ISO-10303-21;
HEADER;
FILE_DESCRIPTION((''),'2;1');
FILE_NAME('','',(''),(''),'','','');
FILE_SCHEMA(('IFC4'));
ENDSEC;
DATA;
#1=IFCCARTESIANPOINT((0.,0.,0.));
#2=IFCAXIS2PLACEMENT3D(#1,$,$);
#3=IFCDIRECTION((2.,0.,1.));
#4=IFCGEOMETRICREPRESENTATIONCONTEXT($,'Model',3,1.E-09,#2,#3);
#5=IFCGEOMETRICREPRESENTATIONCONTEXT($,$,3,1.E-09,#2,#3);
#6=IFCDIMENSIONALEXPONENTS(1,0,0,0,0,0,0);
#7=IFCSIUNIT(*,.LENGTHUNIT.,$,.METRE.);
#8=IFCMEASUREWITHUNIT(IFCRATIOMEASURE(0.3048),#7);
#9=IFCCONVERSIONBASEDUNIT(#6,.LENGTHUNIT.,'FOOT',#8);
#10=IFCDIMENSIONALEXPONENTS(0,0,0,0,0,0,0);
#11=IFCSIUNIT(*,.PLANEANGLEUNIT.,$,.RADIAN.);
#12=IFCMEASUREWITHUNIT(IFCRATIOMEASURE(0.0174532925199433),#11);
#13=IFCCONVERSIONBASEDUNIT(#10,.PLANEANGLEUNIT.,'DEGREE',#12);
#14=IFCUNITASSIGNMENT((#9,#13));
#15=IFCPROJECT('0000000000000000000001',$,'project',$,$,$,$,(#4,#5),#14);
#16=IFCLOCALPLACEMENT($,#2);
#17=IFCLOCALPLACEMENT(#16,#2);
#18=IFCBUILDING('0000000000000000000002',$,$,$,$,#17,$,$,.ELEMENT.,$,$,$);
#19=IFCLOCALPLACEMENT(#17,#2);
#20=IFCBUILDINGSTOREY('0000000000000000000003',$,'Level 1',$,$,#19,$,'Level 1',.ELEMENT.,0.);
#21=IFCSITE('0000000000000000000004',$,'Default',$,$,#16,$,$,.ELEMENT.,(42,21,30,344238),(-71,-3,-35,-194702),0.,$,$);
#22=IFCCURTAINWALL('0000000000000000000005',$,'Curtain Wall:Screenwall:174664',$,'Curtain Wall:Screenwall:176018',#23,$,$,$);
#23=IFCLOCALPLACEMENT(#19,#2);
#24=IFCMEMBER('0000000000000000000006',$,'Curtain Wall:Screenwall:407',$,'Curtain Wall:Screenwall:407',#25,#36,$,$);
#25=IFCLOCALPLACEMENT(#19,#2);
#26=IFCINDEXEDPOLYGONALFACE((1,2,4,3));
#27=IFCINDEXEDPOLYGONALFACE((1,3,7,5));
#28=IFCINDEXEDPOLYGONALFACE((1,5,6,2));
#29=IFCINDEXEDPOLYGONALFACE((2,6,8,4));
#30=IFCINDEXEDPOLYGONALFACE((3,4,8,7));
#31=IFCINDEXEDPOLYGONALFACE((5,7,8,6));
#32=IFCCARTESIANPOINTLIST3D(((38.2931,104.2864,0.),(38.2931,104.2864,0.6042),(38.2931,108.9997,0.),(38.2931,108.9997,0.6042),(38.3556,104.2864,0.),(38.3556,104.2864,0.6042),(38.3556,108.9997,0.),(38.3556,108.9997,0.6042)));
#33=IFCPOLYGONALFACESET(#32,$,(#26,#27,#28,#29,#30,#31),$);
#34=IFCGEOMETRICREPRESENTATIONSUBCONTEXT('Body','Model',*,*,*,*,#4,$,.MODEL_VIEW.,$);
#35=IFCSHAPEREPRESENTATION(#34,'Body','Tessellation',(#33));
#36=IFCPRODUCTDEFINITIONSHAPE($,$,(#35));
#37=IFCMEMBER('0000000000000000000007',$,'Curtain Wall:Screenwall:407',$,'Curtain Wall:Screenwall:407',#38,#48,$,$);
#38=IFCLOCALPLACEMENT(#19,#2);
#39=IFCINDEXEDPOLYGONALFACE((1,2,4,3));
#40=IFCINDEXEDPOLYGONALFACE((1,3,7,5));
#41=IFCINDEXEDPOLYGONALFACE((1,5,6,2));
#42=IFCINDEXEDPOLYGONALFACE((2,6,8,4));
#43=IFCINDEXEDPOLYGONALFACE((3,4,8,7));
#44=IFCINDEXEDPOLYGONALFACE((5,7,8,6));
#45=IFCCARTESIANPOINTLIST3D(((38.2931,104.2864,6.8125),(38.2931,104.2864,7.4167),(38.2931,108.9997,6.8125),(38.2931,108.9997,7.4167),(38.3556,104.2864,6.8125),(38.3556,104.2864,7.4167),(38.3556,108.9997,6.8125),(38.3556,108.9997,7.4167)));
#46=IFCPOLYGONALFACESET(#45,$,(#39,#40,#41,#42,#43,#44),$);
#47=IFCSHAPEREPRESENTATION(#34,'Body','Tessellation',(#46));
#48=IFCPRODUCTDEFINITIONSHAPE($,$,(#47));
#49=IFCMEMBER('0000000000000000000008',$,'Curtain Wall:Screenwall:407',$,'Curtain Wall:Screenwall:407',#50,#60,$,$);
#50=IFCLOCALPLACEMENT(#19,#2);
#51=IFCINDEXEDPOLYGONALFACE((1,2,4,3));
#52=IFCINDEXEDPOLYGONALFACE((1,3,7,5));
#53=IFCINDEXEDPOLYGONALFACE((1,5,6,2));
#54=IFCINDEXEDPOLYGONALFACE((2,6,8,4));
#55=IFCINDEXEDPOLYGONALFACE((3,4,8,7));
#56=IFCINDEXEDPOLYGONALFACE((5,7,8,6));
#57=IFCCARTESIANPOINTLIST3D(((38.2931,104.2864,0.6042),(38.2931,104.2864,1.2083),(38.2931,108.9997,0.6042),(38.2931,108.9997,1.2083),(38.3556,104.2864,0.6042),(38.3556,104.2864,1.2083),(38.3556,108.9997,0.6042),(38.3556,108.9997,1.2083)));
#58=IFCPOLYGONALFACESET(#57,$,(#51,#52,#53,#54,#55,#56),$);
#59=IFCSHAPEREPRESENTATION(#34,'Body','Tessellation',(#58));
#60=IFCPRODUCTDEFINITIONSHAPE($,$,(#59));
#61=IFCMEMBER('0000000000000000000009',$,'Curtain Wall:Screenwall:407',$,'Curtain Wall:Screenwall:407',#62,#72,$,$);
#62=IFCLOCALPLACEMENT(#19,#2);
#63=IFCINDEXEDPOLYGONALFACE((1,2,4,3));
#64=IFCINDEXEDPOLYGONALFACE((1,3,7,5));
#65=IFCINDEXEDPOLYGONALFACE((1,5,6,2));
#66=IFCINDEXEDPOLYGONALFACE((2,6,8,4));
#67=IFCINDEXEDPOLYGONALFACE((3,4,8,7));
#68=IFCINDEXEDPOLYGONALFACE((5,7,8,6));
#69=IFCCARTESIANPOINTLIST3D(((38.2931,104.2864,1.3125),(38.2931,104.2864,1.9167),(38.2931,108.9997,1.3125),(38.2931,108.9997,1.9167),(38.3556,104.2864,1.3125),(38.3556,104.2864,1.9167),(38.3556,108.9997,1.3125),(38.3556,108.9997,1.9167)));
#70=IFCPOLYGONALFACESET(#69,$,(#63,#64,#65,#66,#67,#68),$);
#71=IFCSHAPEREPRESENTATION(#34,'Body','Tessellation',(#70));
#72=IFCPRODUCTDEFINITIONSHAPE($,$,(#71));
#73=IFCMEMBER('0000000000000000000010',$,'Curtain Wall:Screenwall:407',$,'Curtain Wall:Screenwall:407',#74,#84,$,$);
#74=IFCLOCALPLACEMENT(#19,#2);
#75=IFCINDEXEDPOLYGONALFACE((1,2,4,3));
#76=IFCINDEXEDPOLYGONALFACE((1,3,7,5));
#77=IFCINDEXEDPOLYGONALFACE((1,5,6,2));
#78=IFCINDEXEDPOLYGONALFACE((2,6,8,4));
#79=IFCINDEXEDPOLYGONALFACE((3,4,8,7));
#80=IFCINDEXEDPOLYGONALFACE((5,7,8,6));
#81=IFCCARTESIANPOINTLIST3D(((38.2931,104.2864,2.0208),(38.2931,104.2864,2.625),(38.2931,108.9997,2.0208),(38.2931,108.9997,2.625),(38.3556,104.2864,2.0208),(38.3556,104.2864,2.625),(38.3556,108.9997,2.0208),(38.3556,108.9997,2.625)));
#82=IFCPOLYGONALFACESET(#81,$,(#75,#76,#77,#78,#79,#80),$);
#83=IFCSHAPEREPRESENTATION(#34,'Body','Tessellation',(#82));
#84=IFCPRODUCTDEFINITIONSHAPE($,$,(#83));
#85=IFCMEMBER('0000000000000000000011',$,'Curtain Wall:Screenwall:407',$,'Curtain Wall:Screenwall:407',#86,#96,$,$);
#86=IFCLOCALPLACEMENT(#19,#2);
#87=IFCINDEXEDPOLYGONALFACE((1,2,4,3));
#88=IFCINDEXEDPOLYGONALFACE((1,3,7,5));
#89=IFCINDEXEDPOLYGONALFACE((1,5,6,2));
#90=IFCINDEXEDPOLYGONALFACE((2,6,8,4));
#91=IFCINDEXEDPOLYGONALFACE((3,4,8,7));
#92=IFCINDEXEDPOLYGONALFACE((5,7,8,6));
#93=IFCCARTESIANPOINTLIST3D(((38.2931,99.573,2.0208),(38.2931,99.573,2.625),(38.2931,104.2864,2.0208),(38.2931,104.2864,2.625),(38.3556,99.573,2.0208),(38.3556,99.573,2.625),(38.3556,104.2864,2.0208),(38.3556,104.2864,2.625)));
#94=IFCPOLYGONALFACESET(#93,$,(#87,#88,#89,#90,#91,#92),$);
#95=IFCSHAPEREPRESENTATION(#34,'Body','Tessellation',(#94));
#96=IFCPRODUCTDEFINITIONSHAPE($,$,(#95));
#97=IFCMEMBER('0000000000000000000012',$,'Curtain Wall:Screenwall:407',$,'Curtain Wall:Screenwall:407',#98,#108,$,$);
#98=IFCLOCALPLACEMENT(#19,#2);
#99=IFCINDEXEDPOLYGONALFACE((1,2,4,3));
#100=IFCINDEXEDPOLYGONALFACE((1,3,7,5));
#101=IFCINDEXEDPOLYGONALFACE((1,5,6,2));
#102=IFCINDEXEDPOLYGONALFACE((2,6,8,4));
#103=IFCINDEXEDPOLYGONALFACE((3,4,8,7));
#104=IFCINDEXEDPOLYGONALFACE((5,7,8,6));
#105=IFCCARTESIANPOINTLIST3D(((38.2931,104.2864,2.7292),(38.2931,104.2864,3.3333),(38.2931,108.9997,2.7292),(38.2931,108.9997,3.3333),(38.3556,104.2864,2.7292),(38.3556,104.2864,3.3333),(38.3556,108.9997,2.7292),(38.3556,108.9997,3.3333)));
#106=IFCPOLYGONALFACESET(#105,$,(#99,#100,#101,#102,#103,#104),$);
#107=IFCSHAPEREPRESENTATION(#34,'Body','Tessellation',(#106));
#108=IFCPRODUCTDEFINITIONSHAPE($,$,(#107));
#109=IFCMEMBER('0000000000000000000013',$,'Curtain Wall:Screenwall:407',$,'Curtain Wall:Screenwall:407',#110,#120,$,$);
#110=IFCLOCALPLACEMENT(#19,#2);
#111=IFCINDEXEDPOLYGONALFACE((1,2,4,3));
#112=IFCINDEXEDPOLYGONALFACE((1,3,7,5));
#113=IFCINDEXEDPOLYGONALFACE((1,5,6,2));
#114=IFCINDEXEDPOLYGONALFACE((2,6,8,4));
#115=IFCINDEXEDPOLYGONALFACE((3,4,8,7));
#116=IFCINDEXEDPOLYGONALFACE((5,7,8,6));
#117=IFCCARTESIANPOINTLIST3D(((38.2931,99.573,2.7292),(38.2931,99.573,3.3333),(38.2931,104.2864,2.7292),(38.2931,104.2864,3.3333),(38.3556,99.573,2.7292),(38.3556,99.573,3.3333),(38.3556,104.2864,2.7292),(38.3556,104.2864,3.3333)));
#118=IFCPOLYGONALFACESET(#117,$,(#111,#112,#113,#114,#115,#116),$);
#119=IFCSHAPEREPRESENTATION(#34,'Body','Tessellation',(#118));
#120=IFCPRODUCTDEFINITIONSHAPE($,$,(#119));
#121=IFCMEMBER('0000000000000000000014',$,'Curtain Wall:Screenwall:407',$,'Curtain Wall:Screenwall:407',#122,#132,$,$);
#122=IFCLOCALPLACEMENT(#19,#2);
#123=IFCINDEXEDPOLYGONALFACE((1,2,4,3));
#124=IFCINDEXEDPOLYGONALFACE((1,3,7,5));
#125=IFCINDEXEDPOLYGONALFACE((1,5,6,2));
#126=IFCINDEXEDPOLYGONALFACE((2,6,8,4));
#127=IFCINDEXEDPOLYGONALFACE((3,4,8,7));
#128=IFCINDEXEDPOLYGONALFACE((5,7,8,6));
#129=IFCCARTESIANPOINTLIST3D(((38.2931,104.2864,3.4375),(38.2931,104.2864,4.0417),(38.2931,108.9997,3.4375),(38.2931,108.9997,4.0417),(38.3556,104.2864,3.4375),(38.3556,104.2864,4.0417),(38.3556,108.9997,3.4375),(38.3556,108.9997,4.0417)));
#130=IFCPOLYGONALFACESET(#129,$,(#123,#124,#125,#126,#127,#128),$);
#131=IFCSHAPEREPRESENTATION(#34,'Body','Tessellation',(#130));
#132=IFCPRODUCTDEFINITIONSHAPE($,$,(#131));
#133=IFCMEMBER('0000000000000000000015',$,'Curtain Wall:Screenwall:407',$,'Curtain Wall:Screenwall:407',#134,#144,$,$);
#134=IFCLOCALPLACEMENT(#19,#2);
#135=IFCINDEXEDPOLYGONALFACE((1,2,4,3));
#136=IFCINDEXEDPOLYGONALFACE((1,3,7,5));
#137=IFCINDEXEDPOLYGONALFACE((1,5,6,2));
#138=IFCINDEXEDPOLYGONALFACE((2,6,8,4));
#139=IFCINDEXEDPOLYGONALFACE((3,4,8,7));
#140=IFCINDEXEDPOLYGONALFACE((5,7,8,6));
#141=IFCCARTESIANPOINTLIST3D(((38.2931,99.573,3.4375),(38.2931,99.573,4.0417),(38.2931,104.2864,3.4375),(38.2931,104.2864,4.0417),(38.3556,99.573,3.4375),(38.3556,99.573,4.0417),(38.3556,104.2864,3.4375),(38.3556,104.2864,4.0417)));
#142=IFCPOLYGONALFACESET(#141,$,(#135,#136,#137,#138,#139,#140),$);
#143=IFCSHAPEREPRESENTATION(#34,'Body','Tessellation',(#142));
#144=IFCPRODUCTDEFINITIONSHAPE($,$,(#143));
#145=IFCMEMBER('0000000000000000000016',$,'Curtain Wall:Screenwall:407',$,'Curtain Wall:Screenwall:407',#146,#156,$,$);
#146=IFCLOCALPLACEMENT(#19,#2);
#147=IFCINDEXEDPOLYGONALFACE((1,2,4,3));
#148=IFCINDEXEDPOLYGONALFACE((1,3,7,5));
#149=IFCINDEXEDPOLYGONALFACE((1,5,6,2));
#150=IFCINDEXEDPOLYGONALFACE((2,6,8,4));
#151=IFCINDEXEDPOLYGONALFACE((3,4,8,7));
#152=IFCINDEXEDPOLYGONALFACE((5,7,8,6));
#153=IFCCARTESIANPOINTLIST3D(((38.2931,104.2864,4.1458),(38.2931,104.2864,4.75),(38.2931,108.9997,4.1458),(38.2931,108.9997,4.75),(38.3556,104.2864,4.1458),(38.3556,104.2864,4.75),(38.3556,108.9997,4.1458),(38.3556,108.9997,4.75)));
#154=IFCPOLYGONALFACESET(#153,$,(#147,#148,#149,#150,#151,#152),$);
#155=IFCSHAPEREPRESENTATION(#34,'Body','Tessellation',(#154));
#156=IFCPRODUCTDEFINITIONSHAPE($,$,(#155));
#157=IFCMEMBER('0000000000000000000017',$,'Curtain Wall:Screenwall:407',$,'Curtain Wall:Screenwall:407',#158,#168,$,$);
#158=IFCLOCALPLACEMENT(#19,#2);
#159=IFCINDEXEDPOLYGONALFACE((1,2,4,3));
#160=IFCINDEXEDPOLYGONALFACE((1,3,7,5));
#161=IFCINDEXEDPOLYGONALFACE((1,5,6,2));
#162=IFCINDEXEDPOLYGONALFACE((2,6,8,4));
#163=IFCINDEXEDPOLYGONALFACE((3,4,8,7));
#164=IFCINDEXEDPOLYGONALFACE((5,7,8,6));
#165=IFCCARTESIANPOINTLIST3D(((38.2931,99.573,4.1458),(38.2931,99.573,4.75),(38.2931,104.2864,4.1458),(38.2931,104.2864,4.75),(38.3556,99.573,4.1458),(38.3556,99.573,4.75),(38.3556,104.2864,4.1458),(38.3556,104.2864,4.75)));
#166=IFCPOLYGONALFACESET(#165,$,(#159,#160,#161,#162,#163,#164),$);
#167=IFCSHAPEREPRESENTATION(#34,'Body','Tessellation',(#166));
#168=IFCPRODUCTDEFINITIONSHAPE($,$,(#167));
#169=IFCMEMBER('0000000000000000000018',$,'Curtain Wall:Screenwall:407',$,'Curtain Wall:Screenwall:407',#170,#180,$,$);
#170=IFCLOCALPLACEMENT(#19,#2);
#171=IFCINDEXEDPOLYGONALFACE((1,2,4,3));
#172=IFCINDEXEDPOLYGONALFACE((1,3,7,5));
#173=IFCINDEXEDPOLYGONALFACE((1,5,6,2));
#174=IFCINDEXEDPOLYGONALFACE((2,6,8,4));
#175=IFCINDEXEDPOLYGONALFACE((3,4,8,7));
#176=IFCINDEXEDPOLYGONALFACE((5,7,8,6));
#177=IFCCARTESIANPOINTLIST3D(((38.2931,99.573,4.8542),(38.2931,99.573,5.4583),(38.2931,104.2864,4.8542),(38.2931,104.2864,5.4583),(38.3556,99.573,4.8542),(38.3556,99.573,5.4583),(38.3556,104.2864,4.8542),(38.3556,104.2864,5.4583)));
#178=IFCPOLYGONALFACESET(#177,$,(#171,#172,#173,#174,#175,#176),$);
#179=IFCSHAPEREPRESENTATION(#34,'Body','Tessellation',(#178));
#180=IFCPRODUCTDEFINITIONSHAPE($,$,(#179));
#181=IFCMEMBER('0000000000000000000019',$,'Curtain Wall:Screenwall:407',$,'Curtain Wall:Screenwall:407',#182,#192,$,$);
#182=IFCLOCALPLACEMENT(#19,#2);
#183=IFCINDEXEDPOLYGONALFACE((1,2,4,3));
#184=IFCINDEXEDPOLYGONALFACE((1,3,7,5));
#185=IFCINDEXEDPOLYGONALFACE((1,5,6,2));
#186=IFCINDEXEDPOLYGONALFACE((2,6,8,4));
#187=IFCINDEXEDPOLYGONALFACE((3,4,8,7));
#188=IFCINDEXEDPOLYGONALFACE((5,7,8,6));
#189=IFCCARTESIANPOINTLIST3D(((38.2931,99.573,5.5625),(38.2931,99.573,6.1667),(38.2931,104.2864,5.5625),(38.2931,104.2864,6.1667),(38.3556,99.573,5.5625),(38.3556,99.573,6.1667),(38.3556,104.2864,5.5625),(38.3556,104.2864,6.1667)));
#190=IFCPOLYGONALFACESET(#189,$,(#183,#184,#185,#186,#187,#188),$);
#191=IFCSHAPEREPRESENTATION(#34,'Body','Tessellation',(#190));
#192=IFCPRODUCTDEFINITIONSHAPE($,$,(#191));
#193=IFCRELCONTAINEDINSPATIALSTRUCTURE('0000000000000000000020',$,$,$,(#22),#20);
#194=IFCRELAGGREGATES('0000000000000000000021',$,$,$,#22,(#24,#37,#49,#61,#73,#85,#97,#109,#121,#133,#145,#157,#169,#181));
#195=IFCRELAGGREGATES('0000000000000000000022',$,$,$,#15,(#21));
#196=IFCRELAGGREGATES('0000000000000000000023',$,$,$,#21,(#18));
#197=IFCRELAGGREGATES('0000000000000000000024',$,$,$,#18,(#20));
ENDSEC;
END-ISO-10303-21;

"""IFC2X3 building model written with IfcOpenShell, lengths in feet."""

from ifc_helpers import new_model, entity, si_unit, converted_unit, direction, frame, frame_2d, origin, origin_2d_with_axis, place, context, subcontext, project, spatial, rectangle, extrude, element, aggregate, save


model = new_model("IFC2X3")

# Units and contexts
model_context = context("Model", 3, precision=1e-09, world=origin(), true_north=direction((2.0, 0.0, 1.0)))
context_of_model = context(None, 3, precision=1e-09, world=origin(), true_north=direction((2.0, 0.0, 1.0)))
body_context = subcontext(model_context, "Body", "Model", "MODEL_VIEW")
ifc_project = project(units=[converted_unit("LENGTHUNIT", "FOOT", entity("IfcRatioMeasure", 0.3048), si_unit("LENGTHUNIT", "METRE"), dimensions=[1, 0, 0, 0, 0, 0, 0]), converted_unit("PLANEANGLEUNIT", "DEGREE", entity("IfcRatioMeasure", 0.0174532925199433), si_unit("PLANEANGLEUNIT", "RADIAN"), dimensions=[0, 0, 0, 0, 0, 0, 0])], contexts=[model_context, context_of_model])

# Site, building, storey
site_placement = place(None, origin())
site = spatial("IfcSite", under=ifc_project, at=site_placement, Name="Default", CompositionType="ELEMENT", RefLatitude=(42, 21, 30, 344238), RefLongitude=(-71, -3, -35, -194702), RefElevation=0.0)
building_placement = place(site_placement, origin())
building = spatial("IfcBuilding", under=site, at=building_placement, CompositionType="ELEMENT")
storey_placement = place(building_placement, origin())
storey = spatial("IfcBuildingStorey", under=building, at=storey_placement, Name="Level 1", LongName="Level 1", CompositionType="ELEMENT", Elevation=0.0)

# Curtain wall, members
curtain_wall_1_placement = place(storey_placement, origin())
curtain_wall_1 = element("IfcCurtainWall", 1, at=curtain_wall_1_placement, inside=storey, Name="Curtain Wall:Screenwall:174664", ObjectType="Curtain Wall:Screenwall:176018")
member_1_placement = place(curtain_wall_1_placement, frame((38.2931, 104.2864, 0.0)))
member_1 = element("IfcMember", 2, at=member_1_placement, Name="Curtain Wall:Screenwall:407", ObjectType="Curtain Wall:Screenwall:407", context=body_context, shape_type="SweptSolid", body=[
    extrude(rectangle(XDim=4.7134, YDim=0.0625, at=frame_2d((0.0, 0.0), x_axis=(1.0, 0.0))), frame((0.0312, 2.3567, 0.0), z_axis=(0.0, 0.0, 1.0), x_axis=(0.0, -1.0, 0.0)), (0.0, 0.0, 1.0), 0.6042),
])
member_2_placement = place(curtain_wall_1_placement, frame((38.2931, 104.2864, 6.8125)))
member_2 = element("IfcMember", 3, at=member_2_placement, Name="Curtain Wall:Screenwall:407", ObjectType="Curtain Wall:Screenwall:407", context=body_context, shape_type="SweptSolid", body=[
    extrude(rectangle(XDim=4.7134, YDim=0.0625, at=origin_2d_with_axis()), frame((0.0312, 2.3567, 0.0), z_axis=(0.0, 0.0, 1.0), x_axis=(0.0, 1.0, 0.0)), (0.0, 0.0, 1.0), 0.6042),
])
member_3_placement = place(curtain_wall_1_placement, frame((38.2931, 104.2864, 0.6042)))
member_3 = element("IfcMember", 4, at=member_3_placement, Name="Curtain Wall:Screenwall:407", ObjectType="Curtain Wall:Screenwall:407", context=body_context, shape_type="SweptSolid", body=[
    extrude(rectangle(XDim=4.7134, YDim=0.0625, at=origin_2d_with_axis()), frame((0.0312, 2.3567, 0.0), z_axis=(0.0, 0.0, 1.0), x_axis=(0.0, 1.0, 0.0)), (0.0, 0.0, 1.0), 0.6042),
])
member_4_placement = place(curtain_wall_1_placement, frame((38.2931, 104.2864, 1.3125)))
member_4 = element("IfcMember", 5, at=member_4_placement, Name="Curtain Wall:Screenwall:407", ObjectType="Curtain Wall:Screenwall:407", context=body_context, shape_type="SweptSolid", body=[
    extrude(rectangle(XDim=4.7134, YDim=0.0625, at=origin_2d_with_axis()), frame((0.0312, 2.3567, 0.0), z_axis=(0.0, 0.0, 1.0), x_axis=(0.0, 1.0, 0.0)), (0.0, 0.0, 1.0), 0.6042),
])
member_5_placement = place(curtain_wall_1_placement, frame((38.2931, 104.2864, 2.0208)))
member_5 = element("IfcMember", 6, at=member_5_placement, Name="Curtain Wall:Screenwall:407", ObjectType="Curtain Wall:Screenwall:407", context=body_context, shape_type="SweptSolid", body=[
    extrude(rectangle(XDim=4.7134, YDim=0.0625, at=origin_2d_with_axis()), frame((0.0312, 2.3567, 0.0), z_axis=(0.0, 0.0, 1.0), x_axis=(0.0, 1.0, 0.0)), (0.0, 0.0, 1.0), 0.6042),
])
member_6_placement = place(curtain_wall_1_placement, frame((38.2931, 99.573, 2.0208)))
member_6 = element("IfcMember", 7, at=member_6_placement, Name="Curtain Wall:Screenwall:407", ObjectType="Curtain Wall:Screenwall:407", context=body_context, shape_type="SweptSolid", body=[
    extrude(rectangle(XDim=4.7134, YDim=0.0625, at=frame_2d((0.0, 0.0), x_axis=(1.0, 0.0))), frame((0.0312, 2.3567, 0.0), z_axis=(0.0, 0.0, 1.0), x_axis=(0.0, 1.0, 0.0)), (0.0, 0.0, 1.0), 0.6042),
])
member_7_placement = place(curtain_wall_1_placement, frame((38.2931, 104.2864, 2.7292)))
member_7 = element("IfcMember", 8, at=member_7_placement, Name="Curtain Wall:Screenwall:407", ObjectType="Curtain Wall:Screenwall:407", context=body_context, shape_type="SweptSolid", body=[
    extrude(rectangle(XDim=4.7134, YDim=0.0625, at=origin_2d_with_axis()), frame((0.0312, 2.3567, 0.0), z_axis=(0.0, 0.0, 1.0), x_axis=(0.0, 1.0, 0.0)), (0.0, 0.0, 1.0), 0.6042),
])
member_8_placement = place(curtain_wall_1_placement, frame((38.2931, 99.573, 2.7292)))
member_8 = element("IfcMember", 9, at=member_8_placement, Name="Curtain Wall:Screenwall:407", ObjectType="Curtain Wall:Screenwall:407", context=body_context, shape_type="SweptSolid", body=[
    extrude(rectangle(XDim=4.7134, YDim=0.0625, at=frame_2d((0.0, 0.0), x_axis=(1.0, 0.0))), frame((0.0312, 2.3567, 0.0), z_axis=(0.0, 0.0, 1.0), x_axis=(0.0, 1.0, 0.0)), (0.0, 0.0, 1.0), 0.6042),
])
member_9_placement = place(curtain_wall_1_placement, frame((38.2931, 104.2864, 3.4375)))
member_9 = element("IfcMember", 10, at=member_9_placement, Name="Curtain Wall:Screenwall:407", ObjectType="Curtain Wall:Screenwall:407", context=body_context, shape_type="SweptSolid", body=[
    extrude(rectangle(XDim=4.7134, YDim=0.0625, at=origin_2d_with_axis()), frame((0.0312, 2.3567, 0.0), z_axis=(0.0, 0.0, 1.0), x_axis=(0.0, 1.0, 0.0)), (0.0, 0.0, 1.0), 0.6042),
])
member_10_placement = place(curtain_wall_1_placement, frame((38.2931, 99.573, 3.4375)))
member_10 = element("IfcMember", 11, at=member_10_placement, Name="Curtain Wall:Screenwall:407", ObjectType="Curtain Wall:Screenwall:407", context=body_context, shape_type="SweptSolid", body=[
    extrude(rectangle(XDim=4.7134, YDim=0.0625, at=frame_2d((0.0, 0.0), x_axis=(1.0, 0.0))), frame((0.0312, 2.3567, 0.0), z_axis=(0.0, 0.0, 1.0), x_axis=(0.0, 1.0, 0.0)), (0.0, 0.0, 1.0), 0.6042),
])
member_11_placement = place(curtain_wall_1_placement, frame((38.2931, 104.2864, 4.1458)))
member_11 = element("IfcMember", 12, at=member_11_placement, Name="Curtain Wall:Screenwall:407", ObjectType="Curtain Wall:Screenwall:407", context=body_context, shape_type="SweptSolid", body=[
    extrude(rectangle(XDim=4.7134, YDim=0.0625, at=origin_2d_with_axis()), frame((0.0312, 2.3567, 0.0), z_axis=(0.0, 0.0, 1.0), x_axis=(0.0, 1.0, 0.0)), (0.0, 0.0, 1.0), 0.6042),
])
member_12_placement = place(curtain_wall_1_placement, frame((38.2931, 99.573, 4.1458)))
member_12 = element("IfcMember", 13, at=member_12_placement, Name="Curtain Wall:Screenwall:407", ObjectType="Curtain Wall:Screenwall:407", context=body_context, shape_type="SweptSolid", body=[
    extrude(rectangle(XDim=4.7134, YDim=0.0625, at=frame_2d((0.0, 0.0), x_axis=(1.0, 0.0))), frame((0.0312, 2.3567, 0.0), z_axis=(0.0, 0.0, 1.0), x_axis=(0.0, 1.0, 0.0)), (0.0, 0.0, 1.0), 0.6042),
])
member_13_placement = place(curtain_wall_1_placement, frame((38.2931, 99.573, 4.8542)))
member_13 = element("IfcMember", 14, at=member_13_placement, Name="Curtain Wall:Screenwall:407", ObjectType="Curtain Wall:Screenwall:407", context=body_context, shape_type="SweptSolid", body=[
    extrude(rectangle(XDim=4.7134, YDim=0.0625, at=frame_2d((0.0, 0.0), x_axis=(1.0, 0.0))), frame((0.0312, 2.3567, 0.0), z_axis=(0.0, 0.0, 1.0), x_axis=(0.0, 1.0, 0.0)), (0.0, 0.0, 1.0), 0.6042),
])
member_14_placement = place(curtain_wall_1_placement, frame((38.2931, 99.573, 5.5625)))
member_14 = element("IfcMember", 15, at=member_14_placement, Name="Curtain Wall:Screenwall:407", ObjectType="Curtain Wall:Screenwall:407", context=body_context, shape_type="SweptSolid", body=[
    extrude(rectangle(XDim=4.7134, YDim=0.0625, at=frame_2d((0.0, 0.0), x_axis=(1.0, 0.0))), frame((0.0312, 2.3567, 0.0), z_axis=(0.0, 0.0, 1.0), x_axis=(0.0, 1.0, 0.0)), (0.0, 0.0, 1.0), 0.6042),
])
aggregate(curtain_wall_1, [member_1, member_2, member_3, member_4, member_5, member_6, member_7, member_8, member_9, member_10, member_11, member_12, member_13, member_14])

save(model, "model.ifc")
